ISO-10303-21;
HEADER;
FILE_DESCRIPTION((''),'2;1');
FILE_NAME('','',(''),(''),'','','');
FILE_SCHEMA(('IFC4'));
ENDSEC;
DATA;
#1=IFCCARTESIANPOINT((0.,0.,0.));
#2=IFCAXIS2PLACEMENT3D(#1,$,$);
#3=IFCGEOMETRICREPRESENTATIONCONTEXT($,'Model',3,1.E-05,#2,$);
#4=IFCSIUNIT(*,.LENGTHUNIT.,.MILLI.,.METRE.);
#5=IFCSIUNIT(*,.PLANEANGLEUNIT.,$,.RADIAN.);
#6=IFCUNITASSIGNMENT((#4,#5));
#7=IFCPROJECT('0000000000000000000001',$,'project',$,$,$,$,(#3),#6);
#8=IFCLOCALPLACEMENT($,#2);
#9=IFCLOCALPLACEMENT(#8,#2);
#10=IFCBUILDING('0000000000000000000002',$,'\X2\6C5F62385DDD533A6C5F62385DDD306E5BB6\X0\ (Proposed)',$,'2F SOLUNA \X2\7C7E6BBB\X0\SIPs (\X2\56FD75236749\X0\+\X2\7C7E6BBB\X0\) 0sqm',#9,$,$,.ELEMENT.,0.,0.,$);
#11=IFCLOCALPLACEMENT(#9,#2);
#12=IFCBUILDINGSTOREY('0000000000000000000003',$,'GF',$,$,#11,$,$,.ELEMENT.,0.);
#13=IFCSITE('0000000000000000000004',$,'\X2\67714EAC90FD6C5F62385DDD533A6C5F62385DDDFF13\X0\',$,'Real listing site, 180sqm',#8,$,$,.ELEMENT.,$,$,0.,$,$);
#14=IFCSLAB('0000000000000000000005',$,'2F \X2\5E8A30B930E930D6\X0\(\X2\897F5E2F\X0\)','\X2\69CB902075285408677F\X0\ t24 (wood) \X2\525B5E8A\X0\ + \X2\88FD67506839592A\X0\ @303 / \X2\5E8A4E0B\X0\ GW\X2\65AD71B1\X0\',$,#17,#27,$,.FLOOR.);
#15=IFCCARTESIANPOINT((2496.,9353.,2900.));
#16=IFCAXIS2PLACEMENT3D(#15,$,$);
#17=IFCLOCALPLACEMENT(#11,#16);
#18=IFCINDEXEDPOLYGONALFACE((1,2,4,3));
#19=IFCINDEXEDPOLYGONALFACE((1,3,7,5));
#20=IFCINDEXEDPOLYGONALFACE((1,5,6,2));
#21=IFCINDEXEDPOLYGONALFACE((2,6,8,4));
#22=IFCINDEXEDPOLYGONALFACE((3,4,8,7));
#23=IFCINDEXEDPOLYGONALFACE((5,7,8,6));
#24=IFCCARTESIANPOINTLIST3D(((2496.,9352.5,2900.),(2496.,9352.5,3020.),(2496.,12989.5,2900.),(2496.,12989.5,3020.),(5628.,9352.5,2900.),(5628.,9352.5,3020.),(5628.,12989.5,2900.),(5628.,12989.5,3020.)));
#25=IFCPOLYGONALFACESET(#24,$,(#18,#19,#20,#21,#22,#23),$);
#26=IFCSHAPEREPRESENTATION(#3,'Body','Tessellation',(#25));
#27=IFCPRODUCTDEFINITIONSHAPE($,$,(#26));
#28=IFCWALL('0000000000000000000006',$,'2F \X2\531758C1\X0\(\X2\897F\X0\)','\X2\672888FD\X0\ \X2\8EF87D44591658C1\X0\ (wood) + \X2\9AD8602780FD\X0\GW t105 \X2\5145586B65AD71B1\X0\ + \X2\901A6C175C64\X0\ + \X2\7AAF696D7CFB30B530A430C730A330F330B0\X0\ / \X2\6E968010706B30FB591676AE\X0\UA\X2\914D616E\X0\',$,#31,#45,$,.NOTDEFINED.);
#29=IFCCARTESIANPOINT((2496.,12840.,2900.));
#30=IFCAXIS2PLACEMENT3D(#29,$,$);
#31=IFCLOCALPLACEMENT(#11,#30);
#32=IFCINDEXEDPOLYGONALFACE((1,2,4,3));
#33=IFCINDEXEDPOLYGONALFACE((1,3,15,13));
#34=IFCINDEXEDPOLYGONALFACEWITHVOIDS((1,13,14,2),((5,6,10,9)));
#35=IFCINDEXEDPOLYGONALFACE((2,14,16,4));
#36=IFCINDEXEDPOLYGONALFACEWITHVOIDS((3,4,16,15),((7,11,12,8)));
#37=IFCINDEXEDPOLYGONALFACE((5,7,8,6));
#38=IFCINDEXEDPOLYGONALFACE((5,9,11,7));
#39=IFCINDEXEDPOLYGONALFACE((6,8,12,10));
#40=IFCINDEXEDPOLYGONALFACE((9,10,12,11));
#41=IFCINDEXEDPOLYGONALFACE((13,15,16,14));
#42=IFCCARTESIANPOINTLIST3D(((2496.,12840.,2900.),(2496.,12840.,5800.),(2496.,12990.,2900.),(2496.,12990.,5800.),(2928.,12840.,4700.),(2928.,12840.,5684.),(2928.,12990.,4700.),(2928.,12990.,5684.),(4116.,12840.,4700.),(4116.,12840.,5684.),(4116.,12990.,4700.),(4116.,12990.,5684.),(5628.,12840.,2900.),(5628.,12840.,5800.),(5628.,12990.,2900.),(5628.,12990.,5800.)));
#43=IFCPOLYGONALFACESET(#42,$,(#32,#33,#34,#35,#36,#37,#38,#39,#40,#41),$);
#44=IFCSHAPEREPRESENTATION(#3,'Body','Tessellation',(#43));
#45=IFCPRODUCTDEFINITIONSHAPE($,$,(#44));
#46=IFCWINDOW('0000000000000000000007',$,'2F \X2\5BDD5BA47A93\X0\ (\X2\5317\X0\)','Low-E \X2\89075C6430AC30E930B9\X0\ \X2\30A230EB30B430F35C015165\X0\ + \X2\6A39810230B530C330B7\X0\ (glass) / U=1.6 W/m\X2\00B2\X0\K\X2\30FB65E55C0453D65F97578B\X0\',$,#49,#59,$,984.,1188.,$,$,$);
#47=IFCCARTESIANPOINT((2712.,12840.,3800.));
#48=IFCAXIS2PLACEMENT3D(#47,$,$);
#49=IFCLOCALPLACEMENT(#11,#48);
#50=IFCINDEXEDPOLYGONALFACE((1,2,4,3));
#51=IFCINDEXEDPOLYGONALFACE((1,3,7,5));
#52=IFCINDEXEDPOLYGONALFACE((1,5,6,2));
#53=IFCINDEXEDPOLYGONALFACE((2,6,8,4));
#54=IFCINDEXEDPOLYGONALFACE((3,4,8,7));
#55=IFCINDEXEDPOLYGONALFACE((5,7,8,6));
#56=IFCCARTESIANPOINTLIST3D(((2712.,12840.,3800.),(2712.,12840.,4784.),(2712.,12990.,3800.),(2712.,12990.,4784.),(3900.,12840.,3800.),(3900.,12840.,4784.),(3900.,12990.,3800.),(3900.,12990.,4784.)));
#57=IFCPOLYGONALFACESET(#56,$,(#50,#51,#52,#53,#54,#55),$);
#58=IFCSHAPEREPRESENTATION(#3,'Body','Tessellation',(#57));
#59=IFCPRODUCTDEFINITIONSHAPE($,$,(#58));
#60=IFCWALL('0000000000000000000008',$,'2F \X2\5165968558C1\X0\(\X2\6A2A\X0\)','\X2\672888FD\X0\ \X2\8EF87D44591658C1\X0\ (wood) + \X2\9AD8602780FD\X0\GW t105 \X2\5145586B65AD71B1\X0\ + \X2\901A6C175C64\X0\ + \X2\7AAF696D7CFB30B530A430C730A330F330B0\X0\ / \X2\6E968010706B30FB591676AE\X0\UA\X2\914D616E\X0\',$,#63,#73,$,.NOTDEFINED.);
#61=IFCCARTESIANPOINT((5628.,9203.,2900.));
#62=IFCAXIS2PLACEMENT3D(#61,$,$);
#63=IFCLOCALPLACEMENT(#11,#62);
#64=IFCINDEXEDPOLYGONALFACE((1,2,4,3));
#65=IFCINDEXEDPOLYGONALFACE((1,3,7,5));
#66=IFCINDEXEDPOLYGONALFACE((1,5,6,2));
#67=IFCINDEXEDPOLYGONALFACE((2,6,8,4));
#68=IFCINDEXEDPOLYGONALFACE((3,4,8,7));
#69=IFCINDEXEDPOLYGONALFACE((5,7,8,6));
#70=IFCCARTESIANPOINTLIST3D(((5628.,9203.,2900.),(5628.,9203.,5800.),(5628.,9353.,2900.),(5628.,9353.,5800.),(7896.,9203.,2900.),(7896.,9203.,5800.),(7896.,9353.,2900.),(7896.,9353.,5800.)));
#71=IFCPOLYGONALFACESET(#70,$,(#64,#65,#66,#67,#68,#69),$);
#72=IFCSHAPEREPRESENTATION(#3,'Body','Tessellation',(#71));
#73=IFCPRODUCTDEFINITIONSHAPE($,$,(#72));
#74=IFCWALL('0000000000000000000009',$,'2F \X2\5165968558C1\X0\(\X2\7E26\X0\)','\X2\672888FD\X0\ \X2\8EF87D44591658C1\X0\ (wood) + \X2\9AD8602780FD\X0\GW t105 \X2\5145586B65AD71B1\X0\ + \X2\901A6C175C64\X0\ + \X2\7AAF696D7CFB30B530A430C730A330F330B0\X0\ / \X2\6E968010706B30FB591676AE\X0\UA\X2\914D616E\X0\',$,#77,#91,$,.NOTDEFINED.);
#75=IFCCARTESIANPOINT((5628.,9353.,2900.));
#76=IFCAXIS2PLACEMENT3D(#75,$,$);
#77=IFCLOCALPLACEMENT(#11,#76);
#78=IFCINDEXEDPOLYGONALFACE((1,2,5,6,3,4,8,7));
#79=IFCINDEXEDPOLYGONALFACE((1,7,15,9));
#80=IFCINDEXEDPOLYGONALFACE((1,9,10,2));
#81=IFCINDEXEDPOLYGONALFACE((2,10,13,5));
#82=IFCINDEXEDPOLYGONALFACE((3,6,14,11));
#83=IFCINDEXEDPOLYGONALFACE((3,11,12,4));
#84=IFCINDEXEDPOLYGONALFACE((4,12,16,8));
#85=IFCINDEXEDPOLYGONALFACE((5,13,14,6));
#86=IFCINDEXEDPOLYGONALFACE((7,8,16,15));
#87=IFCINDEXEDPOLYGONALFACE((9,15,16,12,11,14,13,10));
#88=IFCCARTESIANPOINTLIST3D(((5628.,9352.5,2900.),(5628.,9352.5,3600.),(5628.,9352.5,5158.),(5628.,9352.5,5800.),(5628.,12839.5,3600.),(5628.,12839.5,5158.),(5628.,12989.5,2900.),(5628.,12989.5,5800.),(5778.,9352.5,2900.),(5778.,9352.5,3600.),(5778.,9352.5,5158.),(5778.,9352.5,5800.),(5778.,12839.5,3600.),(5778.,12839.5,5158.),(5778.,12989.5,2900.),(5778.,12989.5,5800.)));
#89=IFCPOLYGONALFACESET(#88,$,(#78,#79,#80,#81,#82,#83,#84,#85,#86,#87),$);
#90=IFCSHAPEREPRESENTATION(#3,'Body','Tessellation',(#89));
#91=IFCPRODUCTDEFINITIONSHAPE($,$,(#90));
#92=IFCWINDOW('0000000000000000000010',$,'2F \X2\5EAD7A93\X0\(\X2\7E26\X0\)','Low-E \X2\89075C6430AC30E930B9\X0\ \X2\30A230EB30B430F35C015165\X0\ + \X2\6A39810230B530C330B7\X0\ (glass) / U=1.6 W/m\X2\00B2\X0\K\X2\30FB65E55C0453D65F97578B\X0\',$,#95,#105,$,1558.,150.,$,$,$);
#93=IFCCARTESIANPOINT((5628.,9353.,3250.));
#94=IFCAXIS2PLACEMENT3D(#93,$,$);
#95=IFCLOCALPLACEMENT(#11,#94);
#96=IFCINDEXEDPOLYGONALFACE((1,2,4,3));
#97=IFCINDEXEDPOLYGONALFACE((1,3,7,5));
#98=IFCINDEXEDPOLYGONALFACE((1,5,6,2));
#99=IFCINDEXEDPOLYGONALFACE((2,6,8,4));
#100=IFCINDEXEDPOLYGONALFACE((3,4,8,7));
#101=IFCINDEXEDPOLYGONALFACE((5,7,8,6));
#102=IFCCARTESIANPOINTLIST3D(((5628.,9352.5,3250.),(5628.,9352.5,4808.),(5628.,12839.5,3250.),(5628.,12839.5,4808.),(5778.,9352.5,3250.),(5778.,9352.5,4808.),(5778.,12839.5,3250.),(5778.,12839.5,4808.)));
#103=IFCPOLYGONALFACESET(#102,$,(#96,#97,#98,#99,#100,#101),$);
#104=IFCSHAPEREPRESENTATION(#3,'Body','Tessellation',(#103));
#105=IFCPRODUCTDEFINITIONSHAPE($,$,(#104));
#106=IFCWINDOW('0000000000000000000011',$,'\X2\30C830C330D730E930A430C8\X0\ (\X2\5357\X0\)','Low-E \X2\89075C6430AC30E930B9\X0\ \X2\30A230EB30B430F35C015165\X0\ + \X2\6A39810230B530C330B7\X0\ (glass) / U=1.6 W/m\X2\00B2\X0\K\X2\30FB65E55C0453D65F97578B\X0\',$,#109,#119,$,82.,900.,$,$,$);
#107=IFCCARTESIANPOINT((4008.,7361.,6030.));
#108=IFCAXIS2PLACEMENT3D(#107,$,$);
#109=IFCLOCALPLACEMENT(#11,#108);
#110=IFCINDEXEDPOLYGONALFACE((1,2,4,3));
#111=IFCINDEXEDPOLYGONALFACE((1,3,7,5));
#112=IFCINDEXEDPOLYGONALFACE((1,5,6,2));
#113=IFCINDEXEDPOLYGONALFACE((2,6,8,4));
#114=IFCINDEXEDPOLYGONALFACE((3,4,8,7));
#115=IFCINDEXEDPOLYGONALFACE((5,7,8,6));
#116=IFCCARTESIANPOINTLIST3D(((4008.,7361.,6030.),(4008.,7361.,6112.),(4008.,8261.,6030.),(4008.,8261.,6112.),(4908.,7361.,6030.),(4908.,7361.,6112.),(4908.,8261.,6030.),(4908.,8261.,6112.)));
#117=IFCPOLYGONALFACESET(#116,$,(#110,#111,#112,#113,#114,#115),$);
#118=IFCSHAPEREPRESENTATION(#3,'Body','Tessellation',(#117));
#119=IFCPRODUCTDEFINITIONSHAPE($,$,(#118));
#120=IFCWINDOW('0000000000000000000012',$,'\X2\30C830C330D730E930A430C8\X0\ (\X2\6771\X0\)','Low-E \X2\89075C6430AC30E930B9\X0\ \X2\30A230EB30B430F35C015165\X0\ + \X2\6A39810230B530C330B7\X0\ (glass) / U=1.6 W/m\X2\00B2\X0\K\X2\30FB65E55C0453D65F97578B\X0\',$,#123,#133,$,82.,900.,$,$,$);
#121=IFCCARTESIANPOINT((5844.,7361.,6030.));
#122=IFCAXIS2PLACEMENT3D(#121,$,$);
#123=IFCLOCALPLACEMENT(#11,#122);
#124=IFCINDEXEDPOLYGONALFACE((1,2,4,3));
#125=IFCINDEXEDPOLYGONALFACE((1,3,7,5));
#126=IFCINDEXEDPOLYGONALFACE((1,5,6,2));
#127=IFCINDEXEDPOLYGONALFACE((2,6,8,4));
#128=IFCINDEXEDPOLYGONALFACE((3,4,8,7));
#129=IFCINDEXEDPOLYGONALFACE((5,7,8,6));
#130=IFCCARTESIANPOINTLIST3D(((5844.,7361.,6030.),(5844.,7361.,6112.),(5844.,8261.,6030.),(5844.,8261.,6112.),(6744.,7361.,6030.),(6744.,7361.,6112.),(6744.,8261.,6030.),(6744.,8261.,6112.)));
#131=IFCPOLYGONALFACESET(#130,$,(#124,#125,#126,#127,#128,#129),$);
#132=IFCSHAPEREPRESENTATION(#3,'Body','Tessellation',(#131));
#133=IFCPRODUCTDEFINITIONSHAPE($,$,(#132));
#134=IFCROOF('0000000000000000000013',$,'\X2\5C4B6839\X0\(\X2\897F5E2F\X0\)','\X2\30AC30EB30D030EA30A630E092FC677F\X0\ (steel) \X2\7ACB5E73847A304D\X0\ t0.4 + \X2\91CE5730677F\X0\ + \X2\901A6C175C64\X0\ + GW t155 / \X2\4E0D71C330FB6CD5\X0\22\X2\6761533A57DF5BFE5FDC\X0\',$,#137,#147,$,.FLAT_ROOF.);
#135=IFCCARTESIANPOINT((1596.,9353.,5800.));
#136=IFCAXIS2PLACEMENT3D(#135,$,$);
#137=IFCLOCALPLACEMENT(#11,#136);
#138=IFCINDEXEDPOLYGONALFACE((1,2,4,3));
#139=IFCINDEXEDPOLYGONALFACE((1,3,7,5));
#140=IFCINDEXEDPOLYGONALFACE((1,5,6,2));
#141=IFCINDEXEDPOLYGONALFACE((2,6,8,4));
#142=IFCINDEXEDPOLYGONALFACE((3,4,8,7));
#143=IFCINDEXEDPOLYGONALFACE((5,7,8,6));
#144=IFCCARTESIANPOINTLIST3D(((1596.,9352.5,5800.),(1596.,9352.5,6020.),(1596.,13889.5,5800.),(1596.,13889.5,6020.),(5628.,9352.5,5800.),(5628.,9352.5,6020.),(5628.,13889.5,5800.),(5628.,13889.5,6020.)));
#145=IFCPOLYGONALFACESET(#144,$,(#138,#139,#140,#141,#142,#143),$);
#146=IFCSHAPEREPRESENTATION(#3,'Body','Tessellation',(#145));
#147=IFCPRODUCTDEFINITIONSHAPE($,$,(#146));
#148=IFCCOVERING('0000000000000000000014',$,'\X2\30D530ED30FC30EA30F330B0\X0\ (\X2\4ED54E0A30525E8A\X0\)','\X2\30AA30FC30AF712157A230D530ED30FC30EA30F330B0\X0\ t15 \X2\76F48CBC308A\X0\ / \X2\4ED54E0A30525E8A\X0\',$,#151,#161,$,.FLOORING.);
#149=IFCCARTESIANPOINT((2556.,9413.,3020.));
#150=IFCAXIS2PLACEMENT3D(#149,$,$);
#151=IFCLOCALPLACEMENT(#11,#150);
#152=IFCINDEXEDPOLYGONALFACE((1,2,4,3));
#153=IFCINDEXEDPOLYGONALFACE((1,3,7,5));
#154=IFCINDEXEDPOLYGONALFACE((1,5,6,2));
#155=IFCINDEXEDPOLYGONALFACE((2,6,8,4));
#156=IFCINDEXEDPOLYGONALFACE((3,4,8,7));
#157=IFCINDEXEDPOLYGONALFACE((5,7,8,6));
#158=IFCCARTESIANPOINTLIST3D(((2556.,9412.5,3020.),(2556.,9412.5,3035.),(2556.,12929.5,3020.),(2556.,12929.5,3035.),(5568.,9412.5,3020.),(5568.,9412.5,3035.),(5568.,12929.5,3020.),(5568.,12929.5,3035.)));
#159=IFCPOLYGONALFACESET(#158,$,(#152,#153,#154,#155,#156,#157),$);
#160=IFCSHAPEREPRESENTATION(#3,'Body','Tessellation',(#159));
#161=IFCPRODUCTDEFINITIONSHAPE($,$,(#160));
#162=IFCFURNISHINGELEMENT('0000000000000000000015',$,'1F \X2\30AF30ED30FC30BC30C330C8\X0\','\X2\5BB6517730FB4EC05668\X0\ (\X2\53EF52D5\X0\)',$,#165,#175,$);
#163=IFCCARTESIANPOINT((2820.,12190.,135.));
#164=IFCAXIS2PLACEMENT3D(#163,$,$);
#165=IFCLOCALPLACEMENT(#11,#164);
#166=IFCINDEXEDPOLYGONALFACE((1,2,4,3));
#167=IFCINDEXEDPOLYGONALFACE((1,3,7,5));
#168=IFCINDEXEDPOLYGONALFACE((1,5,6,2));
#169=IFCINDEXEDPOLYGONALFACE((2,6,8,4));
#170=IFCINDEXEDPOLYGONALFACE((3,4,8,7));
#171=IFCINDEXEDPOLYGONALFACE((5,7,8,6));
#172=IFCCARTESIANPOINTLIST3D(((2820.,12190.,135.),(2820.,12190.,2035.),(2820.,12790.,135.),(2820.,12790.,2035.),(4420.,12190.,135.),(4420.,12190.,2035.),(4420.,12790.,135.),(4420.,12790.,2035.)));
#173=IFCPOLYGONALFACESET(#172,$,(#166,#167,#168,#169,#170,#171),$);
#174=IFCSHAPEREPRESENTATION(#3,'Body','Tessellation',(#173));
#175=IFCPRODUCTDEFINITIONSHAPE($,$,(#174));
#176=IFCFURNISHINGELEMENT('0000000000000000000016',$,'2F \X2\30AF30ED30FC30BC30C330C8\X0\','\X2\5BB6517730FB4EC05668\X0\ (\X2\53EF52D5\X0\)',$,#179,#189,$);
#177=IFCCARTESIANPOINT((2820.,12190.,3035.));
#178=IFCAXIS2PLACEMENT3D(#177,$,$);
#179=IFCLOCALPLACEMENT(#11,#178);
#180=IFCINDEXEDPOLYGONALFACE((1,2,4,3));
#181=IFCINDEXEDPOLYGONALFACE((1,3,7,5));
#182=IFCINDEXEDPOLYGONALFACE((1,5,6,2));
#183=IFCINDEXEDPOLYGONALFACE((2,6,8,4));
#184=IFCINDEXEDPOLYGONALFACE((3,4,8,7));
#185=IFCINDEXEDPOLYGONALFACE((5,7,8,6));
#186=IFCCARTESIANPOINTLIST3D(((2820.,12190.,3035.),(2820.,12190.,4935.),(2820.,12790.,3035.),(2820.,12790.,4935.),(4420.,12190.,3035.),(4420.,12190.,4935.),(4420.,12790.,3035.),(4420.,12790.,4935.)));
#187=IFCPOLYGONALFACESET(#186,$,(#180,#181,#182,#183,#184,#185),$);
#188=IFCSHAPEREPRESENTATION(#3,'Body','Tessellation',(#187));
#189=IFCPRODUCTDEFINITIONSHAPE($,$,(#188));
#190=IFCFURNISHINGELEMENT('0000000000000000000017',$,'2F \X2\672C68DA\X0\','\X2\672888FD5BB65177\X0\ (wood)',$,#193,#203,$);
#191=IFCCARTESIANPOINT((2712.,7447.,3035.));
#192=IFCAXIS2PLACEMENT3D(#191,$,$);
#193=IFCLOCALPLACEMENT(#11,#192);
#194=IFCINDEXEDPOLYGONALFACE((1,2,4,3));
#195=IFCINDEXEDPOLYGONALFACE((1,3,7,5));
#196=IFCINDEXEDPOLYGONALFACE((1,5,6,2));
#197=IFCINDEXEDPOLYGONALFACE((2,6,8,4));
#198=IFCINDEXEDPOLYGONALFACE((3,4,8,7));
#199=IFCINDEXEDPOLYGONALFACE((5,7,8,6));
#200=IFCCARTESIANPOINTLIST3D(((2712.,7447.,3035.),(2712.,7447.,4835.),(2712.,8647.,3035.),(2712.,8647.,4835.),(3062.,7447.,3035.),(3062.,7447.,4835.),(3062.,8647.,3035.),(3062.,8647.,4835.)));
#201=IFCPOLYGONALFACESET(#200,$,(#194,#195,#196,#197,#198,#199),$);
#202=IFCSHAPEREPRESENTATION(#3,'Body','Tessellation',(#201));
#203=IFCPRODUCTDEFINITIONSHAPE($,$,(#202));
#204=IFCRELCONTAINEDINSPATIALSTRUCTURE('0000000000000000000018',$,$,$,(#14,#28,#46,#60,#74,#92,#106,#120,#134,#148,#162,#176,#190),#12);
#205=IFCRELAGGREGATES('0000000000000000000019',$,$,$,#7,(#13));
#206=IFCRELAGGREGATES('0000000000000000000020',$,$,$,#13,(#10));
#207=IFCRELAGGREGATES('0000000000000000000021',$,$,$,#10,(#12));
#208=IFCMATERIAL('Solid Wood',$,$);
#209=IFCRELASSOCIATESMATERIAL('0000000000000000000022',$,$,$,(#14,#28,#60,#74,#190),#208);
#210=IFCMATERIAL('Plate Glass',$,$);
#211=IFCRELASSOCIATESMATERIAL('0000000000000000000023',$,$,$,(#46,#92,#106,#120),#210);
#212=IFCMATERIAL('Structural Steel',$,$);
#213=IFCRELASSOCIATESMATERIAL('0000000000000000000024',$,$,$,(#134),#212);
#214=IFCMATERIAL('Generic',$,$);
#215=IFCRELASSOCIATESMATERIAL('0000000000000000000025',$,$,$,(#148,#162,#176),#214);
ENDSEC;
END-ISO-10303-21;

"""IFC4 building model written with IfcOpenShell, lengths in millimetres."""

from ifc_helpers import new_model, si_unit, frame, frame_2d, origin, place, context, project, spatial, rectangle, extrude, material, element, fill, save


model = new_model("IFC4")

# Units and contexts
model_context = context("Model", 3, precision=1e-05, world=origin())
ifc_project = project(units=[si_unit("LENGTHUNIT", "METRE", prefix="MILLI"), si_unit("PLANEANGLEUNIT", "RADIAN")], contexts=[model_context])

# Site, building, storey
site_placement = place(None, origin())
site = spatial("IfcSite", under=ifc_project, at=site_placement, Name="東京都江戸川区江戸川３", ObjectType="Real listing site, 180sqm", CompositionType="ELEMENT", RefElevation=0.0)
building_placement = place(site_placement, origin())
building = spatial("IfcBuilding", under=site, at=building_placement, Name="江戸川区江戸川の家 (Proposed)", ObjectType="2F SOLUNA 籾殻SIPs (国産杉+籾殻) 0sqm", CompositionType="ELEMENT", ElevationOfRefHeight=0.0, ElevationOfTerrain=0.0)
storey_placement = place(building_placement, origin())
storey = spatial("IfcBuildingStorey", under=building, at=storey_placement, Name="GF", CompositionType="ELEMENT", Elevation=0.0)

# Slab
ifc_material_1 = material(Name="Solid Wood")
slab_placement = place(storey_placement, frame((2496.0, 9353.0, 2900.0)))
element("IfcSlab", 1, at=slab_placement, inside=storey, material=ifc_material_1, Name="2F 床スラブ(西帯)", Description="構造用合板 t24 (wood) 剛床 + 製材根太 @303 / 床下 GW断熱", PredefinedType="FLOOR", context=model_context, shape_type="SweptSolid", body=[
    extrude(rectangle(XDim=3132.0, YDim=3637.0, at=frame_2d((1566.0, 1818.0))), frame((2496.0, 9353.0, 2900.0)), (0.0, 0.0, 1.0), 120.0),
])

# Wall, opening, window
wall_1_placement = place(storey_placement, frame((2496.0, 12840.0, 2900.0)))
wall_1 = element("IfcWall", 2, at=wall_1_placement, inside=storey, material=ifc_material_1, Name="2F 北壁(西)", Description="木製 軸組外壁 (wood) + 高性能GW t105 充填断熱 + 通気層 + 窯業系サイディング / 準耐火・外皮UA配慮", PredefinedType="NOTDEFINED", context=model_context, shape_type="SweptSolid", body=[
    extrude(rectangle(XDim=3132.0, YDim=150.0, at=frame_2d((1566.0, 75.0))), frame((2496.0, 12840.0, 2900.0)), (0.0, 0.0, 1.0), 2900.0),
])
opening_1_placement = place(storey_placement, frame((2712.0, 12840.0, 3800.0)))
opening_1 = element("IfcOpeningElement", 3, at=opening_1_placement, cuts=wall_1, PredefinedType="NOTDEFINED", context=model_context, shape_type="SweptSolid", body=[
    extrude(rectangle(XDim=1188.0, YDim=150.0, at=frame_2d((594.0, 75.0))), frame((2712.0, 12840.0, 3800.0)), (0.0, 0.0, 1.0), 984.0),
])
ifc_material_2 = material(Name="Plate Glass")
window_1_placement = place(storey_placement, frame((2712.0, 12840.0, 3800.0)))
window_1 = element("IfcWindow", 4, at=window_1_placement, inside=storey, material=ifc_material_2, Name="2F 寝室窓 (北)", Description="Low-E 複層ガラス アルゴン封入 + 樹脂サッシ (glass) / U=1.6 W/m²K・日射取得型", OverallHeight=984.0, OverallWidth=1188.0, context=model_context, shape_type="SweptSolid", body=[
    extrude(rectangle(XDim=1188.0, YDim=150.0, at=frame_2d((594.0, 75.0))), frame((2712.0, 12840.0, 3800.0)), (0.0, 0.0, 1.0), 984.0),
])
fill(opening_1, window_1)

# Wall
wall_2_placement = place(storey_placement, frame((5628.0, 9203.0, 2900.0)))
element("IfcWall", 5, at=wall_2_placement, inside=storey, material=ifc_material_1, Name="2F 入隅壁(横)", Description="木製 軸組外壁 (wood) + 高性能GW t105 充填断熱 + 通気層 + 窯業系サイディング / 準耐火・外皮UA配慮", PredefinedType="NOTDEFINED", context=model_context, shape_type="SweptSolid", body=[
    extrude(rectangle(XDim=2268.0, YDim=150.0, at=frame_2d((1134.0, 75.0))), frame((5628.0, 9203.0, 2900.0)), (0.0, 0.0, 1.0), 2900.0),
])

# Wall, opening, window
wall_3_placement = place(storey_placement, frame((5628.0, 9353.0, 2900.0)))
wall_3 = element("IfcWall", 6, at=wall_3_placement, inside=storey, material=ifc_material_1, Name="2F 入隅壁(縦)", Description="木製 軸組外壁 (wood) + 高性能GW t105 充填断熱 + 通気層 + 窯業系サイディング / 準耐火・外皮UA配慮", PredefinedType="NOTDEFINED", context=model_context, shape_type="SweptSolid", body=[
    extrude(rectangle(XDim=150.0, YDim=3637.0, at=frame_2d((75.0, 1818.0))), frame((5628.0, 9353.0, 2900.0)), (0.0, 0.0, 1.0), 2900.0),
])
opening_2_placement = place(storey_placement, frame((5628.0, 9353.0, 3250.0)))
opening_2 = element("IfcOpeningElement", 7, at=opening_2_placement, cuts=wall_3, PredefinedType="NOTDEFINED", context=model_context, shape_type="SweptSolid", body=[
    extrude(rectangle(XDim=150.0, YDim=3487.0, at=frame_2d((75.0, 1743.0))), frame((5628.0, 9353.0, 3250.0)), (0.0, 0.0, 1.0), 1558.0),
])
window_2_placement = place(storey_placement, frame((5628.0, 9353.0, 3250.0)))
window_2 = element("IfcWindow", 8, at=window_2_placement, inside=storey, material=ifc_material_2, Name="2F 庭窓(縦)", Description="Low-E 複層ガラス アルゴン封入 + 樹脂サッシ (glass) / U=1.6 W/m²K・日射取得型", OverallHeight=1558.0, OverallWidth=150.0, context=model_context, shape_type="SweptSolid", body=[
    extrude(rectangle(XDim=150.0, YDim=3487.0, at=frame_2d((75.0, 1743.0))), frame((5628.0, 9353.0, 3250.0)), (0.0, 0.0, 1.0), 1558.0),
])
fill(opening_2, window_2)

# Windows
window_3_placement = place(storey_placement, frame((4008.0, 7361.0, 6030.0)))
element("IfcWindow", 9, at=window_3_placement, inside=storey, material=ifc_material_2, Name="トップライト (南)", Description="Low-E 複層ガラス アルゴン封入 + 樹脂サッシ (glass) / U=1.6 W/m²K・日射取得型", OverallHeight=82.0, OverallWidth=900.0, context=model_context, shape_type="SweptSolid", body=[
    extrude(rectangle(XDim=900.0, YDim=900.0, at=frame_2d((450.0, 450.0))), frame((4008.0, 7361.0, 6030.0)), (0.0, 0.0, 1.0), 82.0),
])
window_4_placement = place(storey_placement, frame((5844.0, 7361.0, 6030.0)))
element("IfcWindow", 10, at=window_4_placement, inside=storey, material=ifc_material_2, Name="トップライト (東)", Description="Low-E 複層ガラス アルゴン封入 + 樹脂サッシ (glass) / U=1.6 W/m²K・日射取得型", OverallHeight=82.0, OverallWidth=900.0, context=model_context, shape_type="SweptSolid", body=[
    extrude(rectangle(XDim=900.0, YDim=900.0, at=frame_2d((450.0, 450.0))), frame((5844.0, 7361.0, 6030.0)), (0.0, 0.0, 1.0), 82.0),
])

# Roof
ifc_material_3 = material(Name="Structural Steel")
for number, where, name in (
    (11, (1596.0, 9353.0, 5800.0), "屋根(西帯)"),
):
    element("IfcRoof", number, at=place(storey_placement, frame(where)), inside=storey, material=ifc_material_3, Name=name, Description="ガルバリウム鋼板 (steel) 立平葺き t0.4 + 野地板 + 通気層 + GW t155 / 不燃・法22条区域対応", PredefinedType="FLAT_ROOF", context=model_context, shape_type="SweptSolid", body=[
        extrude(rectangle(XDim=4032.0, YDim=4537.0, at=frame_2d((2016.0, 2268.0))), frame((1596.0, 9353.0, 5800.0)), (0.0, 0.0, 1.0), 220.0),
    ])

# Covering
ifc_material_4 = material(Name="Generic")
covering_placement = place(storey_placement, frame((2556.0, 9413.0, 3020.0)))
element("IfcCovering", 12, at=covering_placement, inside=storey, material=ifc_material_4, Name="フローリング (仕上げ床)", Description="オーク無垢フローリング t15 直貼り / 仕上げ床", PredefinedType="FLOORING", context=model_context, shape_type="SweptSolid", body=[
    extrude(rectangle(XDim=3012.0, YDim=3517.0, at=frame_2d((1506.0, 1758.0))), frame((2556.0, 9413.0, 3020.0)), (0.0, 0.0, 1.0), 15.0),
])

# Furnishing elements
furnishing_1_placement = place(storey_placement, frame((2820.0, 12190.0, 135.0)))
element("IfcFurnishingElement", 13, at=furnishing_1_placement, inside=storey, material=ifc_material_4, Name="1F クローゼット", Description="家具・什器 (可動)", context=model_context, shape_type="SweptSolid", body=[
    extrude(rectangle(XDim=1600.0, YDim=600.0, at=frame_2d((800.0, 300.0))), frame((2820.0, 12190.0, 135.0)), (0.0, 0.0, 1.0), 1900.0),
])
furnishing_2_placement = place(storey_placement, frame((2820.0, 12190.0, 3035.0)))
element("IfcFurnishingElement", 14, at=furnishing_2_placement, inside=storey, material=ifc_material_4, Name="2F クローゼット", Description="家具・什器 (可動)", context=model_context, shape_type="SweptSolid", body=[
    extrude(rectangle(XDim=1600.0, YDim=600.0, at=frame_2d((800.0, 300.0))), frame((2820.0, 12190.0, 3035.0)), (0.0, 0.0, 1.0), 1900.0),
])
furnishing_3_placement = place(storey_placement, frame((2712.0, 7447.0, 3035.0)))
element("IfcFurnishingElement", 15, at=furnishing_3_placement, inside=storey, material=ifc_material_1, Name="2F 本棚", Description="木製家具 (wood)", context=model_context, shape_type="SweptSolid", body=[
    extrude(rectangle(XDim=350.0, YDim=1200.0, at=frame_2d((175.0, 600.0))), frame((2712.0, 7447.0, 3035.0)), (0.0, 0.0, 1.0), 1800.0),
])

save(model, "model.ifc")
